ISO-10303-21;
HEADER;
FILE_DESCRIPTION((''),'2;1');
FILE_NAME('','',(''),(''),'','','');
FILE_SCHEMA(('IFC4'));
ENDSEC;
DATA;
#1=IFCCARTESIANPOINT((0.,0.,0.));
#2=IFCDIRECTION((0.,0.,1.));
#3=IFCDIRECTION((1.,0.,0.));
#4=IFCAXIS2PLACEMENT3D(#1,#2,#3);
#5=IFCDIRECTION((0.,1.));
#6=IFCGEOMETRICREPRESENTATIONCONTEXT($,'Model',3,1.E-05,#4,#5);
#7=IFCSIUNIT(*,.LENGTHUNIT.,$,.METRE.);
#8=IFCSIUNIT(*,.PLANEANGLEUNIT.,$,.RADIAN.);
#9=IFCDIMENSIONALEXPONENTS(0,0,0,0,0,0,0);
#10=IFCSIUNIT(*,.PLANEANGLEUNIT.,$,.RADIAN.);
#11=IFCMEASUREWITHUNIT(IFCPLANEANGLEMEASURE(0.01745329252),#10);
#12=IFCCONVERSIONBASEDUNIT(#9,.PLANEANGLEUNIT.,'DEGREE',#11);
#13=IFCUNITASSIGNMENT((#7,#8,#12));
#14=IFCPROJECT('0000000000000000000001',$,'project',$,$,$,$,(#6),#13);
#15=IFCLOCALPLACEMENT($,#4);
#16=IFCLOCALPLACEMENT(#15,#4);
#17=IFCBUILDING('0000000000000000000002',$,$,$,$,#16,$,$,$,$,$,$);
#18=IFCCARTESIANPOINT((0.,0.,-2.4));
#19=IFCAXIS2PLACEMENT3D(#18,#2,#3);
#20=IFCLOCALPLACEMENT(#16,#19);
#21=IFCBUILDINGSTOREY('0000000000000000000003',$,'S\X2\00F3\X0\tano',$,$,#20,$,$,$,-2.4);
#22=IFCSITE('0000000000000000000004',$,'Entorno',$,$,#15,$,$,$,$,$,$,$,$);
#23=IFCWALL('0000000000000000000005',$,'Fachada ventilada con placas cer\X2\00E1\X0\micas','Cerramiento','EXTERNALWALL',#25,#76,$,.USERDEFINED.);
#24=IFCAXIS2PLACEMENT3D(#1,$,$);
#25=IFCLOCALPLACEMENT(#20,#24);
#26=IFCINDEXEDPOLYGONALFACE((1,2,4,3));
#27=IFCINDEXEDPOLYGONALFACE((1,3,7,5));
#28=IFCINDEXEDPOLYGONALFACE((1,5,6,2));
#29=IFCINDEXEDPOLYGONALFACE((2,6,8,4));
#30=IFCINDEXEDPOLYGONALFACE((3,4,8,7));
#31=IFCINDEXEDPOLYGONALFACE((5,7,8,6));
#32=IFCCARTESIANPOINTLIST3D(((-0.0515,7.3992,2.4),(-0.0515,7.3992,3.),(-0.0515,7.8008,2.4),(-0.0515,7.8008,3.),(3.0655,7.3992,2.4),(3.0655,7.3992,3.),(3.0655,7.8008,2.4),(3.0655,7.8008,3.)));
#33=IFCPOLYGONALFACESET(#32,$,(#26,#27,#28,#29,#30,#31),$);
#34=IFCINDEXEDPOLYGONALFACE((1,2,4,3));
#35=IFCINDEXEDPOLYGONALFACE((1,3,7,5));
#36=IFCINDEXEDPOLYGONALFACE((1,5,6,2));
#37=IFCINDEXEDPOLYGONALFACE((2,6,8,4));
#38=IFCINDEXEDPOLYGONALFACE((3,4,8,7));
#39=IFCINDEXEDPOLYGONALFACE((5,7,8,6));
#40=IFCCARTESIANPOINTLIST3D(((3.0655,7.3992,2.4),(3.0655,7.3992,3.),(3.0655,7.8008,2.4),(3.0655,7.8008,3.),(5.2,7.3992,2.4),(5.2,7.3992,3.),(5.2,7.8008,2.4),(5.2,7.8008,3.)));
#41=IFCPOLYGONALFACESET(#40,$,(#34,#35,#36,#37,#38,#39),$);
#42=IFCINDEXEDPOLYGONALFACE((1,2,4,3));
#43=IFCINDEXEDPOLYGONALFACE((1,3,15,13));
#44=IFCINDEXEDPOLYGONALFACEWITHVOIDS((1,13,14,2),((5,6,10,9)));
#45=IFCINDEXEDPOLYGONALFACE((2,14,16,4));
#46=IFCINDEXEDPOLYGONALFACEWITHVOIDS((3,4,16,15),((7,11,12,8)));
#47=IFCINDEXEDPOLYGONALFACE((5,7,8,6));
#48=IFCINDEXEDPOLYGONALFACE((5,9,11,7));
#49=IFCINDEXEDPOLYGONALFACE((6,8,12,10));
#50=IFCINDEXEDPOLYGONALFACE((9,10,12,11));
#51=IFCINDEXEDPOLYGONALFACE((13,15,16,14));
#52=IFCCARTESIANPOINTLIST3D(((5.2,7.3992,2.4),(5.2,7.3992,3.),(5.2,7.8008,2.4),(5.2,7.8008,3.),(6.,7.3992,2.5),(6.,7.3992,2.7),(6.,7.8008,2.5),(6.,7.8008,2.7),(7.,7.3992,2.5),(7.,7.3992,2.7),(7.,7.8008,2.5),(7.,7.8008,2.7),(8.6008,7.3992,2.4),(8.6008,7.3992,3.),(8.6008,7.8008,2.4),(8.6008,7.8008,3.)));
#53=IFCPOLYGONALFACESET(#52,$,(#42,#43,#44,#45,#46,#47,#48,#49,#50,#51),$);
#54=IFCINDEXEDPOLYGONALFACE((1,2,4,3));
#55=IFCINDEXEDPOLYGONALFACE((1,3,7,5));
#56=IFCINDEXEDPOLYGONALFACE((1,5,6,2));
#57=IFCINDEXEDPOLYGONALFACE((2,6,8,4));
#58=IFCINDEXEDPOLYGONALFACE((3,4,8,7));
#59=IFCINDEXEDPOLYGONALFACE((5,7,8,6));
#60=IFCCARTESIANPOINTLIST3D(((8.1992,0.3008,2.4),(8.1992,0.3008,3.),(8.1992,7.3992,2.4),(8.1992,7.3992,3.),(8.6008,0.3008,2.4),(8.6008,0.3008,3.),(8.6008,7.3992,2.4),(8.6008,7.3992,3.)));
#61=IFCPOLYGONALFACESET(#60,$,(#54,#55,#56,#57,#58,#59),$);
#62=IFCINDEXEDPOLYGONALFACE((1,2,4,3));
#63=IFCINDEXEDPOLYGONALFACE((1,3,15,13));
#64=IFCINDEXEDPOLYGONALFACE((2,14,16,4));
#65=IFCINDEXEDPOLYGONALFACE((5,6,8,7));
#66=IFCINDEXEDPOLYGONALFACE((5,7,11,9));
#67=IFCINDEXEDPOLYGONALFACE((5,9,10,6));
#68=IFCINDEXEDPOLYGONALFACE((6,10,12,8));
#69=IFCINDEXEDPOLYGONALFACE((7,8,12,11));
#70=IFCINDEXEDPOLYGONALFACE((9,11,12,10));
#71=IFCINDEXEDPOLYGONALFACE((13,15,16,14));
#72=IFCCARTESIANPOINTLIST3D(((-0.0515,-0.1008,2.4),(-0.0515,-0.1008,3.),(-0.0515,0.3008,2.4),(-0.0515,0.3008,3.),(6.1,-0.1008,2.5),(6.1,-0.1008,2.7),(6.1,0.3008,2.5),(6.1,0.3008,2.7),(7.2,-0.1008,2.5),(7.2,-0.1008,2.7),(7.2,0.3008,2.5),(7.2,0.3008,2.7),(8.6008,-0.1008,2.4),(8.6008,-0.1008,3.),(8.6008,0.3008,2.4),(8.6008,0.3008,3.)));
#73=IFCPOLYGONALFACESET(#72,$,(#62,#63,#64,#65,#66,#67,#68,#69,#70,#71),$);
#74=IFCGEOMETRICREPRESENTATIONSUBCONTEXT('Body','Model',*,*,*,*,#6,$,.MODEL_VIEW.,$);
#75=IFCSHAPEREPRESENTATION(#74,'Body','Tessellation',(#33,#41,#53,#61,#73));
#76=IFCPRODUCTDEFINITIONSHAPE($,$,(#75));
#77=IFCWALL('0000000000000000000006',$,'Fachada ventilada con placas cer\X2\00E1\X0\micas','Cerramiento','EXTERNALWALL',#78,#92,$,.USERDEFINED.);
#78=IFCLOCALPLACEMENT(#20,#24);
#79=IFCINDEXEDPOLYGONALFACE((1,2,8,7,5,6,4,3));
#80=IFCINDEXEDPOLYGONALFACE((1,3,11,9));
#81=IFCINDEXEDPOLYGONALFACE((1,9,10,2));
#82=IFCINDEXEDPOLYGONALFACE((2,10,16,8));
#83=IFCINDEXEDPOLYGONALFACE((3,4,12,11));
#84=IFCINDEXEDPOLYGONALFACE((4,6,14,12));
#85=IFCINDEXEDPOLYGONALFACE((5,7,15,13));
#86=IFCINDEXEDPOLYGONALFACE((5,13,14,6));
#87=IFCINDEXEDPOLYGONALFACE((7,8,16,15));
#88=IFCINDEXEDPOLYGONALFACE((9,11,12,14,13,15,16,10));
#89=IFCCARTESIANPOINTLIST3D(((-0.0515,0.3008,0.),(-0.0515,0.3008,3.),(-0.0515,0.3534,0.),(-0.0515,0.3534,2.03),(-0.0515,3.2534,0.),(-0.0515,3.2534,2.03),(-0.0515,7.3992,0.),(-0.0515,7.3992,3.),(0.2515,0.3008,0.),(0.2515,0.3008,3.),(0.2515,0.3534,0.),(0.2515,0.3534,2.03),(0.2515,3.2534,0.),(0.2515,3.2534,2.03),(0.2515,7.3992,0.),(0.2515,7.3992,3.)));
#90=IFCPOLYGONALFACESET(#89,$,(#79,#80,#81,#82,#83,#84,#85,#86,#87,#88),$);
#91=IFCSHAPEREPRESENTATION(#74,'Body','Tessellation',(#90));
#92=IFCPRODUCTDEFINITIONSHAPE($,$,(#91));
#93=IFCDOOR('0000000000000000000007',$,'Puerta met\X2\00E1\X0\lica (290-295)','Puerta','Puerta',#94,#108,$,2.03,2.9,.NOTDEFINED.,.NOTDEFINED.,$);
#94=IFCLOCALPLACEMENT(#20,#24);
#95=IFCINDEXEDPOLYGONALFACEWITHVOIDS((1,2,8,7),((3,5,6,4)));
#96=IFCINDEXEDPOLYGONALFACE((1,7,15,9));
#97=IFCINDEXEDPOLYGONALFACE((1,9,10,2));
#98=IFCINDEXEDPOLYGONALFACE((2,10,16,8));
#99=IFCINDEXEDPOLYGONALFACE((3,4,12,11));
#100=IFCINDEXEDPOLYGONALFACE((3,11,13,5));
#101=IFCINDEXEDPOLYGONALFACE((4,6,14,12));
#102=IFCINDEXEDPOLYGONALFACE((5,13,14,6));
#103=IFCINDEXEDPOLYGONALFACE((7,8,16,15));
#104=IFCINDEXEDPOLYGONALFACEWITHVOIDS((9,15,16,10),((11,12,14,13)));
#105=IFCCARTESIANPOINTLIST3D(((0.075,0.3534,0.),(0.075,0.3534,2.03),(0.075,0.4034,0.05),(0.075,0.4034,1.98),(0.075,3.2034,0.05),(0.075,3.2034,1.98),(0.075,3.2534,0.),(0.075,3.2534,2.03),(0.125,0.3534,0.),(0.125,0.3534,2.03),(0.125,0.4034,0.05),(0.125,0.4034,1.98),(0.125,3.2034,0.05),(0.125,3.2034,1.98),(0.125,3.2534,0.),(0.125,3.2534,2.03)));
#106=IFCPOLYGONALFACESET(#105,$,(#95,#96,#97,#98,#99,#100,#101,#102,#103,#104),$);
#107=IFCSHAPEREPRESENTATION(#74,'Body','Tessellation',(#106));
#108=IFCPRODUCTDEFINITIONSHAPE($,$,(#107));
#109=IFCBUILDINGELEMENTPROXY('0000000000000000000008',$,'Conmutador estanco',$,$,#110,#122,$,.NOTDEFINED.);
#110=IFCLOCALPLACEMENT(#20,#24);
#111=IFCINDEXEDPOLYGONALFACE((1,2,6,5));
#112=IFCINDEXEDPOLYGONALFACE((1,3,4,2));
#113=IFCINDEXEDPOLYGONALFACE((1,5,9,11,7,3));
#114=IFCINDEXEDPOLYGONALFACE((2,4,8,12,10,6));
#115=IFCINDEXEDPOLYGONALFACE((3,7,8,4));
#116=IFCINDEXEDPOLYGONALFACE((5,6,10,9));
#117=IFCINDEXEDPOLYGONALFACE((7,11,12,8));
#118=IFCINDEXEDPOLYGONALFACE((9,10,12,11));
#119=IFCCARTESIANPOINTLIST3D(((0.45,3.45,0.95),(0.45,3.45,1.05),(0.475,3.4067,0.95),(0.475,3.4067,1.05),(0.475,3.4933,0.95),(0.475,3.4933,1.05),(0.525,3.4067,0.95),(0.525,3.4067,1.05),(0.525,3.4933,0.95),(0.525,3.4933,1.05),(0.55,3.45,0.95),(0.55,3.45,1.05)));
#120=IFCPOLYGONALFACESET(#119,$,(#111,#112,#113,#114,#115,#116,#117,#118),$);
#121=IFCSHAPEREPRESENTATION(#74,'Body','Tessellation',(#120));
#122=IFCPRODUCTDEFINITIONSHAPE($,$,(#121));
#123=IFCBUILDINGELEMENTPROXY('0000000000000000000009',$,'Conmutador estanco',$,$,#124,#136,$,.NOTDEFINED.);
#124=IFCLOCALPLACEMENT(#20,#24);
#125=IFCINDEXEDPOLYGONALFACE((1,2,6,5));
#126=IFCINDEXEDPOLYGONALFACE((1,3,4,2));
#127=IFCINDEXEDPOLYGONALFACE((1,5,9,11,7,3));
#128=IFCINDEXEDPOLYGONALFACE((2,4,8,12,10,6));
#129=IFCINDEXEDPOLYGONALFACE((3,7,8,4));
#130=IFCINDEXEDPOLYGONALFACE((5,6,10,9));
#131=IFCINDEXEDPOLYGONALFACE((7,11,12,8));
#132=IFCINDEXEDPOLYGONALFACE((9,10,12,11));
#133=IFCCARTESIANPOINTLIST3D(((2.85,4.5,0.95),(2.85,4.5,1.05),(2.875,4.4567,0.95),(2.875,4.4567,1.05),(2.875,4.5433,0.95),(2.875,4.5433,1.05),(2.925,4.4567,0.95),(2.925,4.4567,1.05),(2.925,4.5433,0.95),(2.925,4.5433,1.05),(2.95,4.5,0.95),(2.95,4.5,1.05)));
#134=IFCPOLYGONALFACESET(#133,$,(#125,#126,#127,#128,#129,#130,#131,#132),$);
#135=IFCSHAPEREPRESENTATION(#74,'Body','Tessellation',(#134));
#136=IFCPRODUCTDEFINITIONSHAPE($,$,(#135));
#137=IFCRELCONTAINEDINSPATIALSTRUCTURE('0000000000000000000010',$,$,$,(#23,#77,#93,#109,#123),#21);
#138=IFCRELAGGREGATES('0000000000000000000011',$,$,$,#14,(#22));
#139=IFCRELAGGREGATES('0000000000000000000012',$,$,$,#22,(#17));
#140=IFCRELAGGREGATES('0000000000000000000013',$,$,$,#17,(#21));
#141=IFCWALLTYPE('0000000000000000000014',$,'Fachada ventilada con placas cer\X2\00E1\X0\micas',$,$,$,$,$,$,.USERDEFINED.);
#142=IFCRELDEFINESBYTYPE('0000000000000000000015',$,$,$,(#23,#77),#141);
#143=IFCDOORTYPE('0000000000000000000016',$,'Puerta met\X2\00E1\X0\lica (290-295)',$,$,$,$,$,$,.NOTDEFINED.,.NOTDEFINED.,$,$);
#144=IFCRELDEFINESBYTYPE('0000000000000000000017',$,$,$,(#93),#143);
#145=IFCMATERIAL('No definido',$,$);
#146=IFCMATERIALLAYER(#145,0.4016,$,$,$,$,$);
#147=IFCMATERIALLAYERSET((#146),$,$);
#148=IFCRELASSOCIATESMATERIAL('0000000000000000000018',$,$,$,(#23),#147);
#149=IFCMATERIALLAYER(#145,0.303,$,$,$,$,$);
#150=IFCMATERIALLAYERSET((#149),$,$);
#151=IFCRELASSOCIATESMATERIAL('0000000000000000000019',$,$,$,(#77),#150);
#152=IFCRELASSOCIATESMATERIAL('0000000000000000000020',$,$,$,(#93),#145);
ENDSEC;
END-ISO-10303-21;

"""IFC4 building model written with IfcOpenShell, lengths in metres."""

from ifc_helpers import new_model, entity, si_unit, converted_unit, direction, frame, origin_with_axes, origin_2d_with_axis, place, context, subcontext, project, spatial, polyline, rectangle, hollow_rectangle, outline, extrude, shape, source, transform, mapped, material, layer, layer_set, layer_usage, type_object, element, fill, save


model = new_model("IFC4")

# Units and contexts
model_context = context("Model", 3, precision=1e-05, world=origin_with_axes(), true_north=direction((0.0, 1.0)))
body_context = subcontext(model_context, "Body", "Model", "MODEL_VIEW")
footprint_context = subcontext(model_context, "FootPrint", "Model", "MODEL_VIEW")
ifc_project = project(units=[si_unit("LENGTHUNIT", "METRE"), si_unit("PLANEANGLEUNIT", "RADIAN"), converted_unit("PLANEANGLEUNIT", "DEGREE", entity("IfcPlaneAngleMeasure", 0.01745329252), si_unit("PLANEANGLEUNIT", "RADIAN"), dimensions=[0, 0, 0, 0, 0, 0, 0])], contexts=[model_context])

# Site, building, storey
site_placement = place(None, origin_with_axes())
site = spatial("IfcSite", under=ifc_project, at=site_placement, Name="Entorno")
building_placement = place(site_placement, origin_with_axes())
building = spatial("IfcBuilding", under=site, at=building_placement)
storey_placement = place(building_placement, frame((0.0, 0.0, -2.4), z_axis=(0.0, 0.0, 1.0), x_axis=(1.0, 0.0, 0.0)))
storey = spatial("IfcBuildingStorey", under=building, at=storey_placement, Name="Sótano", Elevation=-2.4)

# Shared definitions
ifc_material = material(Name="No definido")

# Wall, openings
ifc_layer_1 = layer(ifc_material, 0.4016)
ifc_layer_set_1 = layer_set([ifc_layer_1])
ifc_layer_usage_1 = layer_usage(ifc_layer_set_1, "AXIS2", "POSITIVE", -0.2008)
wall_type_1 = type_object("IfcWallType", Name="Fachada ventilada con placas cerámicas", PredefinedType="USERDEFINED")
wall_1_placement = place(storey_placement, frame((0.1, 7.6, 0.0), z_axis=(0.0, 0.0, 1.0), x_axis=(1.0, 0.0, 0.0)))
cartesian_point_1 = entity("IfcCartesianPoint", [-1.5585, -0.3])
cartesian_point_2 = entity("IfcCartesianPoint", [-1.5585, -0.3])
cartesian_point_3 = entity("IfcCartesianPoint", [-1.0673, -0.3])
cartesian_point_4 = entity("IfcCartesianPoint", [-1.0673, -0.3])
cartesian_point_5 = entity("IfcCartesianPoint", [-1.7004, -0.3])
cartesian_point_6 = entity("IfcCartesianPoint", [-1.7004, -0.3])
cartesian_point_7 = entity("IfcCartesianPoint", [-3.5492, -0.3])
cartesian_point_8 = entity("IfcCartesianPoint", [-3.5492, -0.3])
cartesian_point_9 = entity("IfcCartesianPoint", [-4.3262, -0.3])
cartesian_point_10 = entity("IfcCartesianPoint", [-4.3262, -0.3])
wall_1 = element("IfcWall", 1, at=wall_1_placement, inside=storey, type_object=wall_type_1, material=ifc_layer_usage_1, Name="Fachada ventilada con placas cerámicas", Description="Cerramiento", ObjectType="EXTERNALWALL", PredefinedType="USERDEFINED", context=body_context, shape_type="SolidModel", body=[
    entity("IfcExtrudedAreaSolidTapered", entity("IfcArbitraryClosedProfileDef", "AREA", None, entity("IfcPolyline", [cartesian_point_1, entity("IfcCartesianPoint", [1.5585, -0.3]), entity("IfcCartesianPoint", [1.5585, 0.3]), entity("IfcCartesianPoint", [-1.5585, 0.3]), cartesian_point_1])), entity("IfcAxis2Placement3D", entity("IfcCartesianPoint", [1.407, 0.2008, 2.7]), entity("IfcDirection", [0.0, -1.0, 0.0]), entity("IfcDirection", [1.0, 0.0, 0.0])), entity("IfcDirection", [0.0, 0.0, 1.0]), 0.4016, entity("IfcArbitraryClosedProfileDef", "AREA", None, entity("IfcPolyline", [cartesian_point_2, entity("IfcCartesianPoint", [1.5585, -0.3]), entity("IfcCartesianPoint", [1.5585, 0.3]), entity("IfcCartesianPoint", [-1.5585, 0.3]), cartesian_point_2]))),
    entity("IfcExtrudedAreaSolidTapered", entity("IfcArbitraryClosedProfileDef", "AREA", None, entity("IfcPolyline", [cartesian_point_3, entity("IfcCartesianPoint", [1.0673, -0.3]), entity("IfcCartesianPoint", [1.0673, 0.3]), entity("IfcCartesianPoint", [-1.0673, 0.3]), cartesian_point_3])), entity("IfcAxis2Placement3D", entity("IfcCartesianPoint", [4.0328, 0.2008, 2.7]), entity("IfcDirection", [0.0, -1.0, 0.0]), entity("IfcDirection", [1.0, 0.0, 0.0])), entity("IfcDirection", [0.0, 0.0, 1.0]), 0.4016, entity("IfcArbitraryClosedProfileDef", "AREA", None, entity("IfcPolyline", [cartesian_point_4, entity("IfcCartesianPoint", [1.0673, -0.3]), entity("IfcCartesianPoint", [1.0673, 0.3]), entity("IfcCartesianPoint", [-1.0673, 0.3]), cartesian_point_4]))),
    entity("IfcExtrudedAreaSolidTapered", entity("IfcArbitraryClosedProfileDef", "AREA", None, entity("IfcPolyline", [cartesian_point_5, entity("IfcCartesianPoint", [1.7004, -0.3]), entity("IfcCartesianPoint", [1.7004, 0.3]), entity("IfcCartesianPoint", [-1.7004, 0.3]), cartesian_point_5])), entity("IfcAxis2Placement3D", entity("IfcCartesianPoint", [6.8004, 0.2008, 2.7]), entity("IfcDirection", [0.0, -1.0, 0.0]), entity("IfcDirection", [1.0, 0.0, 0.0])), entity("IfcDirection", [0.0, 0.0, 1.0]), 0.4016, entity("IfcArbitraryClosedProfileDef", "AREA", None, entity("IfcPolyline", [cartesian_point_6, entity("IfcCartesianPoint", [1.7004, -0.3]), entity("IfcCartesianPoint", [1.7004, 0.3]), entity("IfcCartesianPoint", [-1.7004, 0.3]), cartesian_point_6]))),
    entity("IfcExtrudedAreaSolidTapered", entity("IfcArbitraryClosedProfileDef", "AREA", None, entity("IfcPolyline", [cartesian_point_7, entity("IfcCartesianPoint", [3.5492, -0.3]), entity("IfcCartesianPoint", [3.5492, 0.3]), entity("IfcCartesianPoint", [-3.5492, 0.3]), cartesian_point_7])), entity("IfcAxis2Placement3D", entity("IfcCartesianPoint", [8.5008, -3.75, 2.7]), entity("IfcDirection", [-1.0, 0.0, 0.0]), entity("IfcDirection", [0.0, -1.0, 0.0])), entity("IfcDirection", [0.0, 0.0, 1.0]), 0.4016, entity("IfcArbitraryClosedProfileDef", "AREA", None, entity("IfcPolyline", [cartesian_point_8, entity("IfcCartesianPoint", [3.5492, -0.3]), entity("IfcCartesianPoint", [3.5492, 0.3]), entity("IfcCartesianPoint", [-3.5492, 0.3]), cartesian_point_8]))),
    entity("IfcExtrudedAreaSolidTapered", entity("IfcArbitraryClosedProfileDef", "AREA", None, entity("IfcPolyline", [cartesian_point_9, entity("IfcCartesianPoint", [4.3262, -0.3]), entity("IfcCartesianPoint", [4.3262, 0.3]), entity("IfcCartesianPoint", [-4.3262, 0.3]), cartesian_point_9])), entity("IfcAxis2Placement3D", entity("IfcCartesianPoint", [4.1746, -7.7008, 2.7]), entity("IfcDirection", [0.0, 1.0, 0.0]), entity("IfcDirection", [-1.0, 0.0, 0.0])), entity("IfcDirection", [0.0, 0.0, 1.0]), 0.4016, entity("IfcArbitraryClosedProfileDef", "AREA", None, entity("IfcPolyline", [cartesian_point_10, entity("IfcCartesianPoint", [4.3262, -0.3]), entity("IfcCartesianPoint", [4.3262, 0.3]), entity("IfcCartesianPoint", [-4.3262, 0.3]), cartesian_point_10]))),
])
opening_1_placement = place(wall_1_placement, frame((6.4, 0.0, 2.6), z_axis=(0.0, 0.0, 1.0), x_axis=(1.0, 0.0, 0.0)))
cartesian_point_11 = entity("IfcCartesianPoint", [-0.5, -0.2008])
element("IfcOpeningElement", 2, at=opening_1_placement, cuts=wall_1, ObjectType="No definido", PredefinedType="OPENING", shapes=[
    shape(body_context, "Body", "SweptSolid", [extrude(rectangle(XDim=0.2, YDim=1.0, at=origin_2d_with_axis()), frame((0.0, -0.2008, 0.0), z_axis=(0.0, 1.0, 0.0), x_axis=(0.0, 0.0, 1.0)), (0.0, 0.0, 1.0), 0.4016)]),
    shape(footprint_context, "FootPrint", "GeometricCurveSet", [entity("IfcGeometricCurveSet", [entity("IfcPolyline", [cartesian_point_11, entity("IfcCartesianPoint", [0.5, -0.2008]), entity("IfcCartesianPoint", [0.5, 0.2008]), entity("IfcCartesianPoint", [-0.5, 0.2008]), cartesian_point_11])])]),
])
opening_2_placement = place(wall_1_placement, frame((6.55, -7.5, 2.6), z_axis=(0.0, 0.0, 1.0), x_axis=(-1.0, 0.0, 0.0)))
cartesian_point_12 = entity("IfcCartesianPoint", [-0.55, -0.2008])
element("IfcOpeningElement", 3, at=opening_2_placement, cuts=wall_1, ObjectType="No definido", PredefinedType="OPENING", shapes=[
    shape(body_context, "Body", "SweptSolid", [extrude(rectangle(XDim=0.2, YDim=1.1, at=origin_2d_with_axis()), frame((0.0, -0.2008, 0.0), z_axis=(0.0, 1.0, 0.0), x_axis=(0.0, 0.0, 1.0)), (0.0, 0.0, 1.0), 0.4016)]),
    shape(footprint_context, "FootPrint", "GeometricCurveSet", [entity("IfcGeometricCurveSet", [entity("IfcPolyline", [cartesian_point_12, entity("IfcCartesianPoint", [0.55, -0.2008]), entity("IfcCartesianPoint", [0.55, 0.2008]), entity("IfcCartesianPoint", [-0.55, 0.2008]), cartesian_point_12])])]),
])

# Wall, opening, door
ifc_layer_2 = layer(ifc_material, 0.303)
ifc_layer_set_2 = layer_set([ifc_layer_2])
ifc_layer_usage_2 = layer_usage(ifc_layer_set_2, "AXIS2", "POSITIVE", -0.1515)
wall_2_placement = place(storey_placement, frame((0.1, 0.1, 0.0), z_axis=(0.0, 0.0, 1.0), x_axis=(0.0, 1.0, 0.0)))
cartesian_point_13 = entity("IfcCartesianPoint", [-3.5492, -1.5])
cartesian_point_14 = entity("IfcCartesianPoint", [-3.5492, -1.5])
wall_2 = element("IfcWall", 4, at=wall_2_placement, inside=storey, type_object=wall_type_1, material=ifc_layer_usage_2, Name="Fachada ventilada con placas cerámicas", Description="Cerramiento", ObjectType="EXTERNALWALL", PredefinedType="USERDEFINED", context=body_context, shape_type="SolidModel", body=[
    entity("IfcExtrudedAreaSolidTapered", entity("IfcArbitraryClosedProfileDef", "AREA", None, entity("IfcPolyline", [cartesian_point_13, entity("IfcCartesianPoint", [3.5492, -1.5]), entity("IfcCartesianPoint", [3.5492, 1.5]), entity("IfcCartesianPoint", [-3.5492, 1.5]), cartesian_point_13])), entity("IfcAxis2Placement3D", entity("IfcCartesianPoint", [3.75, 0.1515, 1.5]), entity("IfcDirection", [0.0, -1.0, 0.0]), entity("IfcDirection", [1.0, 0.0, 0.0])), entity("IfcDirection", [0.0, 0.0, 1.0]), 0.303, entity("IfcArbitraryClosedProfileDef", "AREA", None, entity("IfcPolyline", [cartesian_point_14, entity("IfcCartesianPoint", [3.5492, -1.5]), entity("IfcCartesianPoint", [3.5492, 1.5]), entity("IfcCartesianPoint", [-3.5492, 1.5]), cartesian_point_14]))),
])
opening_3_placement = place(wall_2_placement, frame((1.7034, 0.0, 1.015), z_axis=(0.0, 0.0, 1.0), x_axis=(1.0, 0.0, 0.0)))
cartesian_point_15 = entity("IfcCartesianPoint", [-1.45, -0.1515])
opening_3 = element("IfcOpeningElement", 5, at=opening_3_placement, cuts=wall_2, ObjectType="No definido", PredefinedType="OPENING", shapes=[
    shape(body_context, "Body", "SweptSolid", [extrude(rectangle(XDim=2.03, YDim=2.9, at=origin_2d_with_axis()), frame((0.0, -0.1515, 0.0), z_axis=(0.0, 1.0, 0.0), x_axis=(0.0, 0.0, 1.0)), (0.0, 0.0, 1.0), 0.303)]),
    shape(footprint_context, "FootPrint", "GeometricCurveSet", [entity("IfcGeometricCurveSet", [entity("IfcPolyline", [cartesian_point_15, entity("IfcCartesianPoint", [1.45, -0.1515]), entity("IfcCartesianPoint", [1.45, 0.1515]), entity("IfcCartesianPoint", [-1.45, 0.1515]), cartesian_point_15])])]),
])
door_type_1 = type_object("IfcDoorType", Name="Puerta metálica (290-295)", OperationType="NOTDEFINED", PredefinedType="NOTDEFINED")
door_1_placement = place(opening_3_placement, origin_with_axes())
door_1 = element("IfcDoor", 6, at=door_1_placement, inside=storey, type_object=door_type_1, material=ifc_material, Name="Puerta metálica (290-295)", Description="Puerta", ObjectType="Puerta", OperationType="NOTDEFINED", OverallHeight=2.03, OverallWidth=2.9, PredefinedType="NOTDEFINED", context=body_context, shape_type="SweptSolid", body=[
    extrude(hollow_rectangle(XDim=2.9, YDim=2.03, WallThickness=0.05, InnerFilletRadius=0.0, OuterFilletRadius=0.0, at=origin_2d_with_axis()), frame((0.0, 0.025, 0.0), z_axis=(0.0, -1.0, 0.0), x_axis=(1.0, 0.0, 0.0)), (0.0, 0.0, 1.0), 0.05),
])
fill(opening_3, door_1)

# Building element proxies
shared_shape_1 = source(origin_with_axes(), body_context, "Body", "SolidModel", [
    extrude(outline(polyline([(0.05, 0.0), (0.025, 0.0433), (-0.025, 0.0433), (-0.05, 0.0), (-0.025, -0.0433), (0.025, -0.0433), (0.05, 0.0)])), frame((0.0, 0.0, -0.05), z_axis=(0.0, 0.0, 1.0), x_axis=(1.0, 0.0, 0.0)), (0.0, 0.0, 1.0), 0.1),
])
proxy_1_placement = place(storey_placement, frame((0.0, 0.0, 2.4), z_axis=(0.0, 0.0, 1.0), x_axis=(1.0, 0.0, 0.0)))
element("IfcBuildingElementProxy", 7, at=proxy_1_placement, inside=storey, Name="Conmutador estanco", PredefinedType="NOTDEFINED", context=body_context, shape_type="Brep", body=[
    mapped(shared_shape_1, transform((0.5, 3.45, -1.4), x_axis=(1.0, 0.0, 0.0), y_axis=(0.0, 1.0, 0.0), z_axis=(0.0, 0.0, 1.0))),
])
proxy_2_placement = place(storey_placement, frame((0.0, 0.0, 2.4), z_axis=(0.0, 0.0, 1.0), x_axis=(1.0, 0.0, 0.0)))
element("IfcBuildingElementProxy", 8, at=proxy_2_placement, inside=storey, Name="Conmutador estanco", PredefinedType="NOTDEFINED", context=body_context, shape_type="Brep", body=[
    mapped(shared_shape_1, transform((2.9, 4.5, -1.4), x_axis=(1.0, 0.0, 0.0), y_axis=(0.0, 1.0, 0.0), z_axis=(0.0, 0.0, 1.0))),
])

save(model, "model.ifc")
